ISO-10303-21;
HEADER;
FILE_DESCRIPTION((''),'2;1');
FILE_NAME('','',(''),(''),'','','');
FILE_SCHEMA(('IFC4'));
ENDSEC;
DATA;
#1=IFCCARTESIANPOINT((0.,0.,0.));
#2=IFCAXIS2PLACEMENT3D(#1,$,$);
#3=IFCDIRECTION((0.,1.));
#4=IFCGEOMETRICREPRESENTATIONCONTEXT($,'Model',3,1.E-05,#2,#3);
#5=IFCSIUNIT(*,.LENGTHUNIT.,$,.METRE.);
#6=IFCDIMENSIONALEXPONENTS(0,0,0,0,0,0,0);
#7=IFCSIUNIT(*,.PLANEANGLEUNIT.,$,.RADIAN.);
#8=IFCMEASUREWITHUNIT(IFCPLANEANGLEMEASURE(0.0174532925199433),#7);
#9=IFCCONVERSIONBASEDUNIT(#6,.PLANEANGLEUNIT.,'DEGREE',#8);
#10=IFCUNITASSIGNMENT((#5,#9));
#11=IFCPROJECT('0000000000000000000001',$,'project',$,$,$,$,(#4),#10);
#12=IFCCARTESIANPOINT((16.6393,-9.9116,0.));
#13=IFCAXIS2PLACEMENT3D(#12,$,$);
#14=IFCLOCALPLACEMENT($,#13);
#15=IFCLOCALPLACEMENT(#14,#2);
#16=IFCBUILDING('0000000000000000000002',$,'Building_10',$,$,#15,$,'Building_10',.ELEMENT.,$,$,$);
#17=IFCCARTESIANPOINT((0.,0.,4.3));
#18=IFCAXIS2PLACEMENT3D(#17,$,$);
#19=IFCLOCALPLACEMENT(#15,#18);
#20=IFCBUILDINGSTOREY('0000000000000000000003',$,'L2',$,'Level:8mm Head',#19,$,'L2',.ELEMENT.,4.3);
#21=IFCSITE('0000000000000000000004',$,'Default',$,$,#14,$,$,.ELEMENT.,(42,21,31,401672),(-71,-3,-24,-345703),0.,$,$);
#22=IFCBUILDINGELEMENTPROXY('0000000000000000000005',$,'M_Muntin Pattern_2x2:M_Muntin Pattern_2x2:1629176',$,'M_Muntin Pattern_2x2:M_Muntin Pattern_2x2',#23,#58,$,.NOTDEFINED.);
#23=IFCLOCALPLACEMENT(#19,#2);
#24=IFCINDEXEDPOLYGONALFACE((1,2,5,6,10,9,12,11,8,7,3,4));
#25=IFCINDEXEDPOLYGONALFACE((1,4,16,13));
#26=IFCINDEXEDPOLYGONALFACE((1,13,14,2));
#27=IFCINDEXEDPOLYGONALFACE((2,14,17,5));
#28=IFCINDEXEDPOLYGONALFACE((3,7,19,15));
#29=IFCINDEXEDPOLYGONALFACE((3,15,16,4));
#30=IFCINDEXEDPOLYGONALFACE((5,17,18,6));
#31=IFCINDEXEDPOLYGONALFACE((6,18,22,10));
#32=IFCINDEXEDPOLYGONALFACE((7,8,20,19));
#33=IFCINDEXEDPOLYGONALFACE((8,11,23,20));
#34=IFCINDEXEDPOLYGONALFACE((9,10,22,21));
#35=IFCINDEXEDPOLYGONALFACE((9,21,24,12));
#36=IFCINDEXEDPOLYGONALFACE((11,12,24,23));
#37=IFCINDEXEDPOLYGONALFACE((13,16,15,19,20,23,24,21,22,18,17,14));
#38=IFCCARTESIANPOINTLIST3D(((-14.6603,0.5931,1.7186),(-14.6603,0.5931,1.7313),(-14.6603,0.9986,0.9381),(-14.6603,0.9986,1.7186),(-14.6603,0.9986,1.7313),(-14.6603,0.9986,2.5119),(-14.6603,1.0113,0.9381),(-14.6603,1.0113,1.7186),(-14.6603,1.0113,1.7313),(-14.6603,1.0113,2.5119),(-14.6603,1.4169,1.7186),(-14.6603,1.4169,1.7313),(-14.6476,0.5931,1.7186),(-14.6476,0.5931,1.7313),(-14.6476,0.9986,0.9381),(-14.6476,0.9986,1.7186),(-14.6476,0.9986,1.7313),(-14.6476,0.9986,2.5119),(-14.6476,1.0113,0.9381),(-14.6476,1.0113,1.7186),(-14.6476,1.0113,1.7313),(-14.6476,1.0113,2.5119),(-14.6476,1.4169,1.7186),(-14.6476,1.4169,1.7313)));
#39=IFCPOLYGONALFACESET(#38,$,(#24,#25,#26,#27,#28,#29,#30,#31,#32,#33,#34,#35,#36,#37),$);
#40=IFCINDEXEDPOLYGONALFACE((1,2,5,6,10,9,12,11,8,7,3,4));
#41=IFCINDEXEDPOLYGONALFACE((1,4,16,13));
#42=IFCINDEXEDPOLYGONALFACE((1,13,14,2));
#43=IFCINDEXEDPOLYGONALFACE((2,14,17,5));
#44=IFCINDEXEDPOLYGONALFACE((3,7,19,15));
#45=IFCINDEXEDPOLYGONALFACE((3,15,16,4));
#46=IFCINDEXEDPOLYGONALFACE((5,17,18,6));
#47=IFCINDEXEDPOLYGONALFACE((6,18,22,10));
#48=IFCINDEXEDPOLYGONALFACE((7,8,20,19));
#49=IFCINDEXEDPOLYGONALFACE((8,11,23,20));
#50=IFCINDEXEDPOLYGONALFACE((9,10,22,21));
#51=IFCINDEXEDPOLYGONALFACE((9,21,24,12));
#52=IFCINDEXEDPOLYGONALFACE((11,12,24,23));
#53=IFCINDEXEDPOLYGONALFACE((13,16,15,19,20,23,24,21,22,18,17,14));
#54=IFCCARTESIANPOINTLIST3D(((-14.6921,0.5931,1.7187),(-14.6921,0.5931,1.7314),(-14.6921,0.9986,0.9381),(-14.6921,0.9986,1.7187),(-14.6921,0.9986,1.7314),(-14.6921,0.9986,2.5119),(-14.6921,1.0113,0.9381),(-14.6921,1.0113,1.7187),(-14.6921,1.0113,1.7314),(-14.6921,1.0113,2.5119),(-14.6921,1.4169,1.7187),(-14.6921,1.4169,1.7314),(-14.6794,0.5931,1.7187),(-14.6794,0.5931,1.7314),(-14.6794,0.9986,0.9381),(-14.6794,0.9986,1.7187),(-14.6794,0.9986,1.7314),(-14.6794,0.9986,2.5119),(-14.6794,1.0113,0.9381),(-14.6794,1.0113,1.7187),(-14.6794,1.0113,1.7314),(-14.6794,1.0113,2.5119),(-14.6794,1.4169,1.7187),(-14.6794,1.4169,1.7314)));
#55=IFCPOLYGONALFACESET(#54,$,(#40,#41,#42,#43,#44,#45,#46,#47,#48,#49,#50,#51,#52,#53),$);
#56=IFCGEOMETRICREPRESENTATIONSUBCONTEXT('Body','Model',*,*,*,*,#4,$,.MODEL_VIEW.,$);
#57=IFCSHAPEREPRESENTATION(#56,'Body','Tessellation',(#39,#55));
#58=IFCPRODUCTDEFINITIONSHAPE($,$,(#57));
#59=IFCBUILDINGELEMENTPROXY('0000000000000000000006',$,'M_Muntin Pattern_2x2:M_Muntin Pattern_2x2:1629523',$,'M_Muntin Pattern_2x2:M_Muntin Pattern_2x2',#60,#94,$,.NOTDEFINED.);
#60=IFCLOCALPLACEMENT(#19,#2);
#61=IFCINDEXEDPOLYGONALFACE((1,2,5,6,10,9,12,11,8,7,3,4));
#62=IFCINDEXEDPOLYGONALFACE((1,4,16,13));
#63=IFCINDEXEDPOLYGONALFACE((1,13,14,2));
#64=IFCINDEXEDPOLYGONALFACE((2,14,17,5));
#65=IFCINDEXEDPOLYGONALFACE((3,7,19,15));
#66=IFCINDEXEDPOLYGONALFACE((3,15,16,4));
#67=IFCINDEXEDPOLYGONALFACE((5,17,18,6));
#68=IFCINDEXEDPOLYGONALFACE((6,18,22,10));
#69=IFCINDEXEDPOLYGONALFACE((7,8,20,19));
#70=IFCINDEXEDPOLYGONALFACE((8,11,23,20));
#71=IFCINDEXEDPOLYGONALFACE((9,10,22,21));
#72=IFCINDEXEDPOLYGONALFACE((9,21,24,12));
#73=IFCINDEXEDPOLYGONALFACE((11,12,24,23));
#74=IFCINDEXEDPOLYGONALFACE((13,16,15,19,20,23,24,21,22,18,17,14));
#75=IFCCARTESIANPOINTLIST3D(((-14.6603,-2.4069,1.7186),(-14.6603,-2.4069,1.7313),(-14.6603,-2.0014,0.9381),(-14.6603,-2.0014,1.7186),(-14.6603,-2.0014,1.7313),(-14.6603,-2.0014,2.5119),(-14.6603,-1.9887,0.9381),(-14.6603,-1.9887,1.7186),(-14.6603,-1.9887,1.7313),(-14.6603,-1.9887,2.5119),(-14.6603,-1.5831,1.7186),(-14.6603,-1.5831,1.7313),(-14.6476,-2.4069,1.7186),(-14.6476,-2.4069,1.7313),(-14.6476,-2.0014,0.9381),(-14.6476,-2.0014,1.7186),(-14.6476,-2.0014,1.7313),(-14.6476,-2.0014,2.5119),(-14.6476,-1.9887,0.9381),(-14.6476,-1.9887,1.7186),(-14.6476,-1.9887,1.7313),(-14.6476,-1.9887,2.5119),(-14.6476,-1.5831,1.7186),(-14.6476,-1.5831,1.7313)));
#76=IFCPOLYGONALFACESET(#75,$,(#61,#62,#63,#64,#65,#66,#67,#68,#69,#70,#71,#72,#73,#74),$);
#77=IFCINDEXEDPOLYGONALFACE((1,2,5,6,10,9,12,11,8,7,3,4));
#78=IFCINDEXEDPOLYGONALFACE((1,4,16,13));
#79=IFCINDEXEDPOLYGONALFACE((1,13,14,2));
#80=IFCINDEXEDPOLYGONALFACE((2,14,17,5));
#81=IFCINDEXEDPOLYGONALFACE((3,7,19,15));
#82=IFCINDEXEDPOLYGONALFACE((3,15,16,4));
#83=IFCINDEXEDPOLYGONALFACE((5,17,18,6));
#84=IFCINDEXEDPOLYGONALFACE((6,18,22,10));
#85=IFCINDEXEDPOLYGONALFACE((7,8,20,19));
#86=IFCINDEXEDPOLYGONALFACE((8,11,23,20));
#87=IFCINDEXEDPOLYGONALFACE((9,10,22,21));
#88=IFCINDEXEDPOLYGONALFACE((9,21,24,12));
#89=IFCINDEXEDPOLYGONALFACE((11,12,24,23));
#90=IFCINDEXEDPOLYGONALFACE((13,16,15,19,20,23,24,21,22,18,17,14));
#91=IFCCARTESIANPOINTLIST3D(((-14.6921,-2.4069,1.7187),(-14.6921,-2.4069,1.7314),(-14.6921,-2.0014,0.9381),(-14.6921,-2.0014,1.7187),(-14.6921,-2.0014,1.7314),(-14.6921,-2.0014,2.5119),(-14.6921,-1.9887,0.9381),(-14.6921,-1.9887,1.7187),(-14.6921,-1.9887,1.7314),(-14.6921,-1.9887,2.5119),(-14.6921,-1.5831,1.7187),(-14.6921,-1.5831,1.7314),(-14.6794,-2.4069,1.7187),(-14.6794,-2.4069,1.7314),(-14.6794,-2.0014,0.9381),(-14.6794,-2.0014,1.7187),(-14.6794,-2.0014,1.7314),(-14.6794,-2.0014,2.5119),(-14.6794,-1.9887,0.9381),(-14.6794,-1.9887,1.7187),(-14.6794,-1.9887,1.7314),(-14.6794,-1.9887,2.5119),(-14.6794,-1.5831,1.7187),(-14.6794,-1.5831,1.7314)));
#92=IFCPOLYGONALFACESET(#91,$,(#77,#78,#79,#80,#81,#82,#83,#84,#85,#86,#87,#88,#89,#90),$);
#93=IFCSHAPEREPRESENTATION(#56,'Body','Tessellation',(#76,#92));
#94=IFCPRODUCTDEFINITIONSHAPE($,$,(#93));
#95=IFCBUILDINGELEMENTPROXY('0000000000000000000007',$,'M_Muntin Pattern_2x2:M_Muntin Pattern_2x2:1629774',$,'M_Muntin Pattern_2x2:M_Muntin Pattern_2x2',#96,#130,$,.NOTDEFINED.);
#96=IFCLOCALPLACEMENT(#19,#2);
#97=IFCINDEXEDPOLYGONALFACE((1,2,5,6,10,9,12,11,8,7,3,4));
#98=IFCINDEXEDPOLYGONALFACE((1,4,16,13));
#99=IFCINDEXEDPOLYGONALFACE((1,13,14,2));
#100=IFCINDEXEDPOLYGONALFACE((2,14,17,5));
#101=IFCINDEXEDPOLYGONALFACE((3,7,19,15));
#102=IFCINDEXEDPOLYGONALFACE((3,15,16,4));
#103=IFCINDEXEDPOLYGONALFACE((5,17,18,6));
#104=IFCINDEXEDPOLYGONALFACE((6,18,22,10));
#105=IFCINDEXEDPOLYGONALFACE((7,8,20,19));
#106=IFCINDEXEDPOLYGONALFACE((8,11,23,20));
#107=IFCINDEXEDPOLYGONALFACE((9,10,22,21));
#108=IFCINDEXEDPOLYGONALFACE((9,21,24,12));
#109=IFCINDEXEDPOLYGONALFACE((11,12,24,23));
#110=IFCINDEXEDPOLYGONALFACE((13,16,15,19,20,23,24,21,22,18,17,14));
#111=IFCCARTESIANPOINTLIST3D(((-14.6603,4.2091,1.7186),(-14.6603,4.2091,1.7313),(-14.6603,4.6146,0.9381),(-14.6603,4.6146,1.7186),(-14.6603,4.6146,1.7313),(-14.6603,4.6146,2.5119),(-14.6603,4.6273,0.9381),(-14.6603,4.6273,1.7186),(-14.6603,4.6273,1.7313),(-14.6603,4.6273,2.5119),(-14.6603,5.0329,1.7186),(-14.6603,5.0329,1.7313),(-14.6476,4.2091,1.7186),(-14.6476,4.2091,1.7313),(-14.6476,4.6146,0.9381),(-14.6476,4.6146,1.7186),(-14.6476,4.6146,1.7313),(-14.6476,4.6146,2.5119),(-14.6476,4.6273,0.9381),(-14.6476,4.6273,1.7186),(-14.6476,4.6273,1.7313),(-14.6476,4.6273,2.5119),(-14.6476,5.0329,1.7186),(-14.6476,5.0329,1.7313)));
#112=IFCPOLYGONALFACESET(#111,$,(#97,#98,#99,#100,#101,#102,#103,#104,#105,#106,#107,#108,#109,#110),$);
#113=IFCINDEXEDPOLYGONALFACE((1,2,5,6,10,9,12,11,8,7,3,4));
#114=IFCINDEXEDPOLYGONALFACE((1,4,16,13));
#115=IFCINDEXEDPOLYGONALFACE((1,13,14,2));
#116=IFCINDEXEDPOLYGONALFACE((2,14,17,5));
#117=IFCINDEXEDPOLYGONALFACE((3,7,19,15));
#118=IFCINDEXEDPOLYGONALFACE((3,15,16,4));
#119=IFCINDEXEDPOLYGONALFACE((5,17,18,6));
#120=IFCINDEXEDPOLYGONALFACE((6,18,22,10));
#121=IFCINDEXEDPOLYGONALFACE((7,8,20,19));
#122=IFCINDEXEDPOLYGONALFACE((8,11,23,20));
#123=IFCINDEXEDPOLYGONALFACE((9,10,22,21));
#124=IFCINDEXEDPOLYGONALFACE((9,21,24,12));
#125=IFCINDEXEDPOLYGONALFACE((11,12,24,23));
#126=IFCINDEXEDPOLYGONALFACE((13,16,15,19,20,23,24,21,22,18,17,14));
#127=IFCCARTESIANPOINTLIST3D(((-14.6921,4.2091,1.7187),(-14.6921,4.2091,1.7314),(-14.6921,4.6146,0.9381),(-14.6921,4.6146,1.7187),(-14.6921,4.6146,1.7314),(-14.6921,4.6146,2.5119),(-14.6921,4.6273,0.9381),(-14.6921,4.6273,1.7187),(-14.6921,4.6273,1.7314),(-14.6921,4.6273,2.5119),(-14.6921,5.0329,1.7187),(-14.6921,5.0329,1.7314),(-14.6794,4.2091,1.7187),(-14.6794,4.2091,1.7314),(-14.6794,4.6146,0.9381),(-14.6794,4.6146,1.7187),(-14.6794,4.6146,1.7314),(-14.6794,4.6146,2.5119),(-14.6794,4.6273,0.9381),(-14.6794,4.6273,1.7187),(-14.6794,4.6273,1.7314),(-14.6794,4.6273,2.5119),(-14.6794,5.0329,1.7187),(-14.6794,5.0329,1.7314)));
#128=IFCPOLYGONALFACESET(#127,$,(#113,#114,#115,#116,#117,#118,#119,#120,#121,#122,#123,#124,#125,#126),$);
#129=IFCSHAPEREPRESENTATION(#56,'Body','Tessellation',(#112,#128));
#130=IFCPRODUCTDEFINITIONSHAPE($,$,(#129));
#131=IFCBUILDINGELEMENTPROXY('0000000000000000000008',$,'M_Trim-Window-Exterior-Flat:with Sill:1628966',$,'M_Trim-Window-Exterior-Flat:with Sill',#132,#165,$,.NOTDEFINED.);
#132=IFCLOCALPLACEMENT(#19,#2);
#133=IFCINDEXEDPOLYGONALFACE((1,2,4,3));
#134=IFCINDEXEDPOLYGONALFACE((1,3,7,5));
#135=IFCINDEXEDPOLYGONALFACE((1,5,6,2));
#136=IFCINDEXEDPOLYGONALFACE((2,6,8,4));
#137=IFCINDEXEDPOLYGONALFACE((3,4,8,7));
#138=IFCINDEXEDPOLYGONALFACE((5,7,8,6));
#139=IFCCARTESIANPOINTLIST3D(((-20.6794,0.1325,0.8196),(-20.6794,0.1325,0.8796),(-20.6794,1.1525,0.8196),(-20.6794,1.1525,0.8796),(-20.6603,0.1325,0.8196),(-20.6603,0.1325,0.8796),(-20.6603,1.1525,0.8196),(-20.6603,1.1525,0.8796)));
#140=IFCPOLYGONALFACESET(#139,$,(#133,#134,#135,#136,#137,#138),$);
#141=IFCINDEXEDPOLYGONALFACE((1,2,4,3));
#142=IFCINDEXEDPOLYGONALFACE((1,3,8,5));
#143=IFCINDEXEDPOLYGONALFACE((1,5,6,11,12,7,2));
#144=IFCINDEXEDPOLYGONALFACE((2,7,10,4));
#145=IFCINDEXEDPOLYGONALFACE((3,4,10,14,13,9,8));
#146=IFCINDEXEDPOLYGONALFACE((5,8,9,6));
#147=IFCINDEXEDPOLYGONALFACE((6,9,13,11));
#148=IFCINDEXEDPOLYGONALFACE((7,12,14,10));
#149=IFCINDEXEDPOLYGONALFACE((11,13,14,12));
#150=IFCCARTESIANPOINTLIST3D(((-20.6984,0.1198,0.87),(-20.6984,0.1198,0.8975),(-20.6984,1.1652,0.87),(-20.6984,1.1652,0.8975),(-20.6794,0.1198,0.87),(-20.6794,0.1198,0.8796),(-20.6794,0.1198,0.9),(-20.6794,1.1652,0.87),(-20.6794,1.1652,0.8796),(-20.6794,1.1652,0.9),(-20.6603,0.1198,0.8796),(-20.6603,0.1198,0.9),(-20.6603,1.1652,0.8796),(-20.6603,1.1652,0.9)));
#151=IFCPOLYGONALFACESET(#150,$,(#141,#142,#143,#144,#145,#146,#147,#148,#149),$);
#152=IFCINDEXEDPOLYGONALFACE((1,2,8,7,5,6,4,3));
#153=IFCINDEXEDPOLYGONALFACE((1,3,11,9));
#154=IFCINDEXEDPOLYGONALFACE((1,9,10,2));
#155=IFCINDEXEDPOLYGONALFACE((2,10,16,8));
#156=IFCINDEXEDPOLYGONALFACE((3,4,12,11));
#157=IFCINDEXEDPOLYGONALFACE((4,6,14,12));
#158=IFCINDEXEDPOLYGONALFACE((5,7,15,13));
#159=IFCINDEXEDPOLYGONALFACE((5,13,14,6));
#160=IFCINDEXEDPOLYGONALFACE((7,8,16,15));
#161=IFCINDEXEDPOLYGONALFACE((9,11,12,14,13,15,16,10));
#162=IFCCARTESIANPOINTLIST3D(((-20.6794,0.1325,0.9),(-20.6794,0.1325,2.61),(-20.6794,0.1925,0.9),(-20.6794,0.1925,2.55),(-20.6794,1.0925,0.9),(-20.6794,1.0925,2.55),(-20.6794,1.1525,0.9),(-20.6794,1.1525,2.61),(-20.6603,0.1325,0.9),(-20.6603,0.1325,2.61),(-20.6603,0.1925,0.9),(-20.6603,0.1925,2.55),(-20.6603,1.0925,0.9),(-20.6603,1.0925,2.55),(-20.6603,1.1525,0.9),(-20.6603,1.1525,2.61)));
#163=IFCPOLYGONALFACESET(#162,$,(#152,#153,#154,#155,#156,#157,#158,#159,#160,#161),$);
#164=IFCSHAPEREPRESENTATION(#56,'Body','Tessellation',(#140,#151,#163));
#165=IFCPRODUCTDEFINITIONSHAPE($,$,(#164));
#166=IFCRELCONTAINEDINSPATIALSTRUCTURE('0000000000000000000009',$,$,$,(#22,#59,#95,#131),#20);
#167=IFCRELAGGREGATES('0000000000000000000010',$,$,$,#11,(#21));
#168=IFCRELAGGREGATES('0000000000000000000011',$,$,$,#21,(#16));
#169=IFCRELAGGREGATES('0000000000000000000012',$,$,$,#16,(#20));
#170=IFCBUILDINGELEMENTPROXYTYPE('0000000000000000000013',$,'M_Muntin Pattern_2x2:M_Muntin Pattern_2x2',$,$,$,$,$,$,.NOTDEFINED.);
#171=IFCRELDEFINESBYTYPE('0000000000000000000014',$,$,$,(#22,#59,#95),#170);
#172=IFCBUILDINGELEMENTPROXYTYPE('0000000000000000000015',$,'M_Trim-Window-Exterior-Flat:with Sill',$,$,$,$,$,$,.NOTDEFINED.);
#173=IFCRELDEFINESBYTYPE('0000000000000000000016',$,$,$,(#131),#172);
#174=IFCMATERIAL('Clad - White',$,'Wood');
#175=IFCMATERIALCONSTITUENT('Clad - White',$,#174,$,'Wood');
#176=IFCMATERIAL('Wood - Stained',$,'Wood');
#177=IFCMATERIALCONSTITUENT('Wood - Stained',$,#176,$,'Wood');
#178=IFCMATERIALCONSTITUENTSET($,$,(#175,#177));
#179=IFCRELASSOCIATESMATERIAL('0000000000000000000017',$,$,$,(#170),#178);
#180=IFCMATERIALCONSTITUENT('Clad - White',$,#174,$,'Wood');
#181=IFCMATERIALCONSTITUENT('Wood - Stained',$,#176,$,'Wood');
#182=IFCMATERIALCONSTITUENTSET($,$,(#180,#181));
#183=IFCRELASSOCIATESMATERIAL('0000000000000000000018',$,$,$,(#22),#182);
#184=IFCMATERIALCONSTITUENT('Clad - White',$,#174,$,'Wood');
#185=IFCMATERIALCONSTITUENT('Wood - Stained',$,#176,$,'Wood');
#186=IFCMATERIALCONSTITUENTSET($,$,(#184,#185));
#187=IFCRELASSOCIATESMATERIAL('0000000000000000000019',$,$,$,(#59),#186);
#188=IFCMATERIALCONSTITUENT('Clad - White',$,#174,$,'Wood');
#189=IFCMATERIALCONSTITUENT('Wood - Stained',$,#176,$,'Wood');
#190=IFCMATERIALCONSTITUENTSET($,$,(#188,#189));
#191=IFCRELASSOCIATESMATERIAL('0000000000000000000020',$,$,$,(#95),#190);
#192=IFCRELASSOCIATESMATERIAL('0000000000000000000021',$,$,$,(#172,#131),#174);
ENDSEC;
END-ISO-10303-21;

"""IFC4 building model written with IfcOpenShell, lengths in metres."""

from ifc_helpers import new_model, entity, si_unit, converted_unit, direction, frame, origin, place, context, subcontext, project, spatial, indexed_curve, outline, extrude, source, transform, mapped, material, constituent, constituent_set, type_object, type_shapes, element, save


model = new_model("IFC4")

# Units and contexts
model_context = context("Model", 3, precision=1e-05, world=origin(), true_north=direction((0.0, 1.0)))
body_context = subcontext(model_context, "Body", "Model", "MODEL_VIEW")
ifc_project = project(units=[si_unit("LENGTHUNIT", "METRE"), converted_unit("PLANEANGLEUNIT", "DEGREE", entity("IfcPlaneAngleMeasure", 0.0174532925199433), si_unit("PLANEANGLEUNIT", "RADIAN"), dimensions=[0, 0, 0, 0, 0, 0, 0])], contexts=[model_context])

# Site, building, storey
site_placement = place(None, frame((16.6393, -9.9116, 0.0)))
site = spatial("IfcSite", under=ifc_project, at=site_placement, Name="Default", CompositionType="ELEMENT", RefLatitude=(42, 21, 31, 401672), RefLongitude=(-71, -3, -24, -345703), RefElevation=0.0)
building_placement = place(site_placement, origin())
building = spatial("IfcBuilding", under=site, at=building_placement, Name="Building_10", LongName="Building_10", CompositionType="ELEMENT")
storey_placement = place(building_placement, frame((0.0, 0.0, 4.3)))
storey = spatial("IfcBuildingStorey", under=building, at=storey_placement, Name="L2", ObjectType="Level:8mm Head", LongName="L2", CompositionType="ELEMENT", Elevation=4.3)

# Shared definitions
ifc_material_1 = material(Name="Clad - White", Category="Wood")
ifc_material_2 = material(Name="Wood - Stained", Category="Wood")

# Building element proxies
ifc_constituent_1 = constituent(ifc_material_1, Name="Clad - White", Category="Wood")
ifc_constituent_2 = constituent(ifc_material_2, Name="Wood - Stained", Category="Wood")
ifc_constituent_set_1 = constituent_set(constituents=[ifc_constituent_1, ifc_constituent_2])
building_element_proxy_type_1 = type_object("IfcBuildingElementProxyType", Name="M_Muntin Pattern_2x2:M_Muntin Pattern_2x2", PredefinedType="NOTDEFINED", material=ifc_constituent_set_1)
shared_shape_1 = source(origin(), body_context, "Body", "SweptSolid", [
    extrude(outline(indexed_curve([(0.0064, -0.0064), (0.7869, -0.0064), (0.7869, 0.0063), (0.0064, 0.0063), (0.0064, 0.4119), (-0.0063, 0.4119), (-0.0063, 0.0063), (-0.7869, 0.0063), (-0.7869, -0.0064), (-0.0063, -0.0064), (-0.0063, -0.4119), (0.0064, -0.4119), (0.0064, -0.0064)], self_intersect=False)), frame((0.0, -0.0222, 0.7869), z_axis=(0.0, 1.0, 0.0), x_axis=(0.0, 0.0, 1.0)), (0.0, 0.0, 1.0), 0.0127),
    extrude(outline(indexed_curve([(0.0064, -0.0064), (0.7869, -0.0064), (0.7869, 0.0063), (0.0064, 0.0063), (0.0064, 0.4119), (-0.0063, 0.4119), (-0.0063, 0.0063), (-0.7869, 0.0063), (-0.7869, -0.0064), (-0.0063, -0.0064), (-0.0063, -0.4119), (0.0064, -0.4119), (0.0064, -0.0064)], self_intersect=False)), frame((0.0, 0.0095, 0.7869), z_axis=(0.0, 1.0, 0.0), x_axis=(0.0, 0.0, 1.0)), (0.0, 0.0, 1.0), 0.0127),
])
type_shapes(building_element_proxy_type_1, [shared_shape_1])
ifc_constituent_3 = constituent(ifc_material_1, Name="Clad - White", Category="Wood")
ifc_constituent_4 = constituent(ifc_material_2, Name="Wood - Stained", Category="Wood")
ifc_constituent_set_2 = constituent_set(constituents=[ifc_constituent_3, ifc_constituent_4])
proxy_1_placement = place(storey_placement, frame((-14.6698, 1.005, 0.9381), z_axis=(0.0, 0.0, 1.0), x_axis=(0.0, 1.0, 0.0)))
element("IfcBuildingElementProxy", 1, at=proxy_1_placement, inside=storey, type_object=building_element_proxy_type_1, material=ifc_constituent_set_2, Name="M_Muntin Pattern_2x2:M_Muntin Pattern_2x2:1629176", ObjectType="M_Muntin Pattern_2x2:M_Muntin Pattern_2x2", PredefinedType="NOTDEFINED", context=body_context, shape_type="MappedRepresentation", body=[
    mapped(shared_shape_1, transform((0.0, 0.0, 0.0), scale=1.0)),
])
ifc_constituent_5 = constituent(ifc_material_1, Name="Clad - White", Category="Wood")
ifc_constituent_6 = constituent(ifc_material_2, Name="Wood - Stained", Category="Wood")
ifc_constituent_set_3 = constituent_set(constituents=[ifc_constituent_5, ifc_constituent_6])
proxy_2_placement = place(storey_placement, frame((-14.6698, -1.995, 0.9381), z_axis=(0.0, 0.0, 1.0), x_axis=(0.0, 1.0, 0.0)))
element("IfcBuildingElementProxy", 2, at=proxy_2_placement, inside=storey, type_object=building_element_proxy_type_1, material=ifc_constituent_set_3, Name="M_Muntin Pattern_2x2:M_Muntin Pattern_2x2:1629523", ObjectType="M_Muntin Pattern_2x2:M_Muntin Pattern_2x2", PredefinedType="NOTDEFINED", context=body_context, shape_type="MappedRepresentation", body=[
    mapped(shared_shape_1, transform((0.0, 0.0, 0.0), scale=1.0)),
])
ifc_constituent_7 = constituent(ifc_material_1, Name="Clad - White", Category="Wood")
ifc_constituent_8 = constituent(ifc_material_2, Name="Wood - Stained", Category="Wood")
ifc_constituent_set_4 = constituent_set(constituents=[ifc_constituent_7, ifc_constituent_8])
proxy_3_placement = place(storey_placement, frame((-14.6698, 4.621, 0.9381), z_axis=(0.0, 0.0, 1.0), x_axis=(0.0, 1.0, 0.0)))
element("IfcBuildingElementProxy", 3, at=proxy_3_placement, inside=storey, type_object=building_element_proxy_type_1, material=ifc_constituent_set_4, Name="M_Muntin Pattern_2x2:M_Muntin Pattern_2x2:1629774", ObjectType="M_Muntin Pattern_2x2:M_Muntin Pattern_2x2", PredefinedType="NOTDEFINED", context=body_context, shape_type="MappedRepresentation", body=[
    mapped(shared_shape_1, transform((0.0, 0.0, 0.0), scale=1.0)),
])
building_element_proxy_type_2 = type_object("IfcBuildingElementProxyType", Name="M_Trim-Window-Exterior-Flat:with Sill", PredefinedType="NOTDEFINED", material=ifc_material_1)
shared_shape_2 = source(origin(), body_context, "Body", "SweptSolid", [
    extrude(outline(indexed_curve([(-0.51, -0.03), (0.51, -0.03), (0.51, 0.03), (-0.51, 0.03), (-0.51, -0.03)], self_intersect=False)), frame((0.0, -1.7004, 0.0), z_axis=(0.0, 0.0, 1.0), x_axis=(-1.0, 0.0, 0.0)), (0.0, 0.0, 1.0), 0.0191),
    extrude(outline(indexed_curve([(-0.019, -0.0152), (0.0, -0.0152), (0.0, -0.0057), (0.019, -0.0057), (0.019, 0.0148), (0.0, 0.0148), (-0.019, 0.0123), (-0.019, -0.0152)], self_intersect=False)), frame((-0.5227, -1.6648, 0.019), z_axis=(1.0, 0.0, 0.0), x_axis=(0.0, 0.0, -1.0)), (0.0, 0.0, 1.0), 1.0454),
    extrude(outline(indexed_curve([(-0.87, -0.51), (0.84, -0.51), (0.84, -0.45), (-0.81, -0.45), (-0.81, 0.45), (0.84, 0.45), (0.84, 0.51), (-0.87, 0.51), (-0.87, -0.51)], self_intersect=False)), frame((0.0, -0.81, 0.0), z_axis=(0.0, 0.0, 1.0), x_axis=(0.0, -1.0, 0.0)), (0.0, 0.0, 1.0), 0.0191),
])
type_shapes(building_element_proxy_type_2, [shared_shape_2])
for number, where, z_axis, x_axis, name in (
    (4, (-20.6603, 0.6425, 2.55), (-1.0, 0.0, 0.0), (0.0, -1.0, 0.0), "M_Trim-Window-Exterior-Flat:with Sill:1628966"),
):
    element("IfcBuildingElementProxy", number, at=place(storey_placement, frame(where, z_axis=z_axis, x_axis=x_axis)), inside=storey, type_object=building_element_proxy_type_2, material=ifc_material_1, Name=name, ObjectType="M_Trim-Window-Exterior-Flat:with Sill", PredefinedType="NOTDEFINED", context=body_context, shape_type="MappedRepresentation", body=[
        mapped(shared_shape_2, transform((0.0, 0.0, 0.0), scale=1.0)),
    ])

save(model, "model.ifc")
